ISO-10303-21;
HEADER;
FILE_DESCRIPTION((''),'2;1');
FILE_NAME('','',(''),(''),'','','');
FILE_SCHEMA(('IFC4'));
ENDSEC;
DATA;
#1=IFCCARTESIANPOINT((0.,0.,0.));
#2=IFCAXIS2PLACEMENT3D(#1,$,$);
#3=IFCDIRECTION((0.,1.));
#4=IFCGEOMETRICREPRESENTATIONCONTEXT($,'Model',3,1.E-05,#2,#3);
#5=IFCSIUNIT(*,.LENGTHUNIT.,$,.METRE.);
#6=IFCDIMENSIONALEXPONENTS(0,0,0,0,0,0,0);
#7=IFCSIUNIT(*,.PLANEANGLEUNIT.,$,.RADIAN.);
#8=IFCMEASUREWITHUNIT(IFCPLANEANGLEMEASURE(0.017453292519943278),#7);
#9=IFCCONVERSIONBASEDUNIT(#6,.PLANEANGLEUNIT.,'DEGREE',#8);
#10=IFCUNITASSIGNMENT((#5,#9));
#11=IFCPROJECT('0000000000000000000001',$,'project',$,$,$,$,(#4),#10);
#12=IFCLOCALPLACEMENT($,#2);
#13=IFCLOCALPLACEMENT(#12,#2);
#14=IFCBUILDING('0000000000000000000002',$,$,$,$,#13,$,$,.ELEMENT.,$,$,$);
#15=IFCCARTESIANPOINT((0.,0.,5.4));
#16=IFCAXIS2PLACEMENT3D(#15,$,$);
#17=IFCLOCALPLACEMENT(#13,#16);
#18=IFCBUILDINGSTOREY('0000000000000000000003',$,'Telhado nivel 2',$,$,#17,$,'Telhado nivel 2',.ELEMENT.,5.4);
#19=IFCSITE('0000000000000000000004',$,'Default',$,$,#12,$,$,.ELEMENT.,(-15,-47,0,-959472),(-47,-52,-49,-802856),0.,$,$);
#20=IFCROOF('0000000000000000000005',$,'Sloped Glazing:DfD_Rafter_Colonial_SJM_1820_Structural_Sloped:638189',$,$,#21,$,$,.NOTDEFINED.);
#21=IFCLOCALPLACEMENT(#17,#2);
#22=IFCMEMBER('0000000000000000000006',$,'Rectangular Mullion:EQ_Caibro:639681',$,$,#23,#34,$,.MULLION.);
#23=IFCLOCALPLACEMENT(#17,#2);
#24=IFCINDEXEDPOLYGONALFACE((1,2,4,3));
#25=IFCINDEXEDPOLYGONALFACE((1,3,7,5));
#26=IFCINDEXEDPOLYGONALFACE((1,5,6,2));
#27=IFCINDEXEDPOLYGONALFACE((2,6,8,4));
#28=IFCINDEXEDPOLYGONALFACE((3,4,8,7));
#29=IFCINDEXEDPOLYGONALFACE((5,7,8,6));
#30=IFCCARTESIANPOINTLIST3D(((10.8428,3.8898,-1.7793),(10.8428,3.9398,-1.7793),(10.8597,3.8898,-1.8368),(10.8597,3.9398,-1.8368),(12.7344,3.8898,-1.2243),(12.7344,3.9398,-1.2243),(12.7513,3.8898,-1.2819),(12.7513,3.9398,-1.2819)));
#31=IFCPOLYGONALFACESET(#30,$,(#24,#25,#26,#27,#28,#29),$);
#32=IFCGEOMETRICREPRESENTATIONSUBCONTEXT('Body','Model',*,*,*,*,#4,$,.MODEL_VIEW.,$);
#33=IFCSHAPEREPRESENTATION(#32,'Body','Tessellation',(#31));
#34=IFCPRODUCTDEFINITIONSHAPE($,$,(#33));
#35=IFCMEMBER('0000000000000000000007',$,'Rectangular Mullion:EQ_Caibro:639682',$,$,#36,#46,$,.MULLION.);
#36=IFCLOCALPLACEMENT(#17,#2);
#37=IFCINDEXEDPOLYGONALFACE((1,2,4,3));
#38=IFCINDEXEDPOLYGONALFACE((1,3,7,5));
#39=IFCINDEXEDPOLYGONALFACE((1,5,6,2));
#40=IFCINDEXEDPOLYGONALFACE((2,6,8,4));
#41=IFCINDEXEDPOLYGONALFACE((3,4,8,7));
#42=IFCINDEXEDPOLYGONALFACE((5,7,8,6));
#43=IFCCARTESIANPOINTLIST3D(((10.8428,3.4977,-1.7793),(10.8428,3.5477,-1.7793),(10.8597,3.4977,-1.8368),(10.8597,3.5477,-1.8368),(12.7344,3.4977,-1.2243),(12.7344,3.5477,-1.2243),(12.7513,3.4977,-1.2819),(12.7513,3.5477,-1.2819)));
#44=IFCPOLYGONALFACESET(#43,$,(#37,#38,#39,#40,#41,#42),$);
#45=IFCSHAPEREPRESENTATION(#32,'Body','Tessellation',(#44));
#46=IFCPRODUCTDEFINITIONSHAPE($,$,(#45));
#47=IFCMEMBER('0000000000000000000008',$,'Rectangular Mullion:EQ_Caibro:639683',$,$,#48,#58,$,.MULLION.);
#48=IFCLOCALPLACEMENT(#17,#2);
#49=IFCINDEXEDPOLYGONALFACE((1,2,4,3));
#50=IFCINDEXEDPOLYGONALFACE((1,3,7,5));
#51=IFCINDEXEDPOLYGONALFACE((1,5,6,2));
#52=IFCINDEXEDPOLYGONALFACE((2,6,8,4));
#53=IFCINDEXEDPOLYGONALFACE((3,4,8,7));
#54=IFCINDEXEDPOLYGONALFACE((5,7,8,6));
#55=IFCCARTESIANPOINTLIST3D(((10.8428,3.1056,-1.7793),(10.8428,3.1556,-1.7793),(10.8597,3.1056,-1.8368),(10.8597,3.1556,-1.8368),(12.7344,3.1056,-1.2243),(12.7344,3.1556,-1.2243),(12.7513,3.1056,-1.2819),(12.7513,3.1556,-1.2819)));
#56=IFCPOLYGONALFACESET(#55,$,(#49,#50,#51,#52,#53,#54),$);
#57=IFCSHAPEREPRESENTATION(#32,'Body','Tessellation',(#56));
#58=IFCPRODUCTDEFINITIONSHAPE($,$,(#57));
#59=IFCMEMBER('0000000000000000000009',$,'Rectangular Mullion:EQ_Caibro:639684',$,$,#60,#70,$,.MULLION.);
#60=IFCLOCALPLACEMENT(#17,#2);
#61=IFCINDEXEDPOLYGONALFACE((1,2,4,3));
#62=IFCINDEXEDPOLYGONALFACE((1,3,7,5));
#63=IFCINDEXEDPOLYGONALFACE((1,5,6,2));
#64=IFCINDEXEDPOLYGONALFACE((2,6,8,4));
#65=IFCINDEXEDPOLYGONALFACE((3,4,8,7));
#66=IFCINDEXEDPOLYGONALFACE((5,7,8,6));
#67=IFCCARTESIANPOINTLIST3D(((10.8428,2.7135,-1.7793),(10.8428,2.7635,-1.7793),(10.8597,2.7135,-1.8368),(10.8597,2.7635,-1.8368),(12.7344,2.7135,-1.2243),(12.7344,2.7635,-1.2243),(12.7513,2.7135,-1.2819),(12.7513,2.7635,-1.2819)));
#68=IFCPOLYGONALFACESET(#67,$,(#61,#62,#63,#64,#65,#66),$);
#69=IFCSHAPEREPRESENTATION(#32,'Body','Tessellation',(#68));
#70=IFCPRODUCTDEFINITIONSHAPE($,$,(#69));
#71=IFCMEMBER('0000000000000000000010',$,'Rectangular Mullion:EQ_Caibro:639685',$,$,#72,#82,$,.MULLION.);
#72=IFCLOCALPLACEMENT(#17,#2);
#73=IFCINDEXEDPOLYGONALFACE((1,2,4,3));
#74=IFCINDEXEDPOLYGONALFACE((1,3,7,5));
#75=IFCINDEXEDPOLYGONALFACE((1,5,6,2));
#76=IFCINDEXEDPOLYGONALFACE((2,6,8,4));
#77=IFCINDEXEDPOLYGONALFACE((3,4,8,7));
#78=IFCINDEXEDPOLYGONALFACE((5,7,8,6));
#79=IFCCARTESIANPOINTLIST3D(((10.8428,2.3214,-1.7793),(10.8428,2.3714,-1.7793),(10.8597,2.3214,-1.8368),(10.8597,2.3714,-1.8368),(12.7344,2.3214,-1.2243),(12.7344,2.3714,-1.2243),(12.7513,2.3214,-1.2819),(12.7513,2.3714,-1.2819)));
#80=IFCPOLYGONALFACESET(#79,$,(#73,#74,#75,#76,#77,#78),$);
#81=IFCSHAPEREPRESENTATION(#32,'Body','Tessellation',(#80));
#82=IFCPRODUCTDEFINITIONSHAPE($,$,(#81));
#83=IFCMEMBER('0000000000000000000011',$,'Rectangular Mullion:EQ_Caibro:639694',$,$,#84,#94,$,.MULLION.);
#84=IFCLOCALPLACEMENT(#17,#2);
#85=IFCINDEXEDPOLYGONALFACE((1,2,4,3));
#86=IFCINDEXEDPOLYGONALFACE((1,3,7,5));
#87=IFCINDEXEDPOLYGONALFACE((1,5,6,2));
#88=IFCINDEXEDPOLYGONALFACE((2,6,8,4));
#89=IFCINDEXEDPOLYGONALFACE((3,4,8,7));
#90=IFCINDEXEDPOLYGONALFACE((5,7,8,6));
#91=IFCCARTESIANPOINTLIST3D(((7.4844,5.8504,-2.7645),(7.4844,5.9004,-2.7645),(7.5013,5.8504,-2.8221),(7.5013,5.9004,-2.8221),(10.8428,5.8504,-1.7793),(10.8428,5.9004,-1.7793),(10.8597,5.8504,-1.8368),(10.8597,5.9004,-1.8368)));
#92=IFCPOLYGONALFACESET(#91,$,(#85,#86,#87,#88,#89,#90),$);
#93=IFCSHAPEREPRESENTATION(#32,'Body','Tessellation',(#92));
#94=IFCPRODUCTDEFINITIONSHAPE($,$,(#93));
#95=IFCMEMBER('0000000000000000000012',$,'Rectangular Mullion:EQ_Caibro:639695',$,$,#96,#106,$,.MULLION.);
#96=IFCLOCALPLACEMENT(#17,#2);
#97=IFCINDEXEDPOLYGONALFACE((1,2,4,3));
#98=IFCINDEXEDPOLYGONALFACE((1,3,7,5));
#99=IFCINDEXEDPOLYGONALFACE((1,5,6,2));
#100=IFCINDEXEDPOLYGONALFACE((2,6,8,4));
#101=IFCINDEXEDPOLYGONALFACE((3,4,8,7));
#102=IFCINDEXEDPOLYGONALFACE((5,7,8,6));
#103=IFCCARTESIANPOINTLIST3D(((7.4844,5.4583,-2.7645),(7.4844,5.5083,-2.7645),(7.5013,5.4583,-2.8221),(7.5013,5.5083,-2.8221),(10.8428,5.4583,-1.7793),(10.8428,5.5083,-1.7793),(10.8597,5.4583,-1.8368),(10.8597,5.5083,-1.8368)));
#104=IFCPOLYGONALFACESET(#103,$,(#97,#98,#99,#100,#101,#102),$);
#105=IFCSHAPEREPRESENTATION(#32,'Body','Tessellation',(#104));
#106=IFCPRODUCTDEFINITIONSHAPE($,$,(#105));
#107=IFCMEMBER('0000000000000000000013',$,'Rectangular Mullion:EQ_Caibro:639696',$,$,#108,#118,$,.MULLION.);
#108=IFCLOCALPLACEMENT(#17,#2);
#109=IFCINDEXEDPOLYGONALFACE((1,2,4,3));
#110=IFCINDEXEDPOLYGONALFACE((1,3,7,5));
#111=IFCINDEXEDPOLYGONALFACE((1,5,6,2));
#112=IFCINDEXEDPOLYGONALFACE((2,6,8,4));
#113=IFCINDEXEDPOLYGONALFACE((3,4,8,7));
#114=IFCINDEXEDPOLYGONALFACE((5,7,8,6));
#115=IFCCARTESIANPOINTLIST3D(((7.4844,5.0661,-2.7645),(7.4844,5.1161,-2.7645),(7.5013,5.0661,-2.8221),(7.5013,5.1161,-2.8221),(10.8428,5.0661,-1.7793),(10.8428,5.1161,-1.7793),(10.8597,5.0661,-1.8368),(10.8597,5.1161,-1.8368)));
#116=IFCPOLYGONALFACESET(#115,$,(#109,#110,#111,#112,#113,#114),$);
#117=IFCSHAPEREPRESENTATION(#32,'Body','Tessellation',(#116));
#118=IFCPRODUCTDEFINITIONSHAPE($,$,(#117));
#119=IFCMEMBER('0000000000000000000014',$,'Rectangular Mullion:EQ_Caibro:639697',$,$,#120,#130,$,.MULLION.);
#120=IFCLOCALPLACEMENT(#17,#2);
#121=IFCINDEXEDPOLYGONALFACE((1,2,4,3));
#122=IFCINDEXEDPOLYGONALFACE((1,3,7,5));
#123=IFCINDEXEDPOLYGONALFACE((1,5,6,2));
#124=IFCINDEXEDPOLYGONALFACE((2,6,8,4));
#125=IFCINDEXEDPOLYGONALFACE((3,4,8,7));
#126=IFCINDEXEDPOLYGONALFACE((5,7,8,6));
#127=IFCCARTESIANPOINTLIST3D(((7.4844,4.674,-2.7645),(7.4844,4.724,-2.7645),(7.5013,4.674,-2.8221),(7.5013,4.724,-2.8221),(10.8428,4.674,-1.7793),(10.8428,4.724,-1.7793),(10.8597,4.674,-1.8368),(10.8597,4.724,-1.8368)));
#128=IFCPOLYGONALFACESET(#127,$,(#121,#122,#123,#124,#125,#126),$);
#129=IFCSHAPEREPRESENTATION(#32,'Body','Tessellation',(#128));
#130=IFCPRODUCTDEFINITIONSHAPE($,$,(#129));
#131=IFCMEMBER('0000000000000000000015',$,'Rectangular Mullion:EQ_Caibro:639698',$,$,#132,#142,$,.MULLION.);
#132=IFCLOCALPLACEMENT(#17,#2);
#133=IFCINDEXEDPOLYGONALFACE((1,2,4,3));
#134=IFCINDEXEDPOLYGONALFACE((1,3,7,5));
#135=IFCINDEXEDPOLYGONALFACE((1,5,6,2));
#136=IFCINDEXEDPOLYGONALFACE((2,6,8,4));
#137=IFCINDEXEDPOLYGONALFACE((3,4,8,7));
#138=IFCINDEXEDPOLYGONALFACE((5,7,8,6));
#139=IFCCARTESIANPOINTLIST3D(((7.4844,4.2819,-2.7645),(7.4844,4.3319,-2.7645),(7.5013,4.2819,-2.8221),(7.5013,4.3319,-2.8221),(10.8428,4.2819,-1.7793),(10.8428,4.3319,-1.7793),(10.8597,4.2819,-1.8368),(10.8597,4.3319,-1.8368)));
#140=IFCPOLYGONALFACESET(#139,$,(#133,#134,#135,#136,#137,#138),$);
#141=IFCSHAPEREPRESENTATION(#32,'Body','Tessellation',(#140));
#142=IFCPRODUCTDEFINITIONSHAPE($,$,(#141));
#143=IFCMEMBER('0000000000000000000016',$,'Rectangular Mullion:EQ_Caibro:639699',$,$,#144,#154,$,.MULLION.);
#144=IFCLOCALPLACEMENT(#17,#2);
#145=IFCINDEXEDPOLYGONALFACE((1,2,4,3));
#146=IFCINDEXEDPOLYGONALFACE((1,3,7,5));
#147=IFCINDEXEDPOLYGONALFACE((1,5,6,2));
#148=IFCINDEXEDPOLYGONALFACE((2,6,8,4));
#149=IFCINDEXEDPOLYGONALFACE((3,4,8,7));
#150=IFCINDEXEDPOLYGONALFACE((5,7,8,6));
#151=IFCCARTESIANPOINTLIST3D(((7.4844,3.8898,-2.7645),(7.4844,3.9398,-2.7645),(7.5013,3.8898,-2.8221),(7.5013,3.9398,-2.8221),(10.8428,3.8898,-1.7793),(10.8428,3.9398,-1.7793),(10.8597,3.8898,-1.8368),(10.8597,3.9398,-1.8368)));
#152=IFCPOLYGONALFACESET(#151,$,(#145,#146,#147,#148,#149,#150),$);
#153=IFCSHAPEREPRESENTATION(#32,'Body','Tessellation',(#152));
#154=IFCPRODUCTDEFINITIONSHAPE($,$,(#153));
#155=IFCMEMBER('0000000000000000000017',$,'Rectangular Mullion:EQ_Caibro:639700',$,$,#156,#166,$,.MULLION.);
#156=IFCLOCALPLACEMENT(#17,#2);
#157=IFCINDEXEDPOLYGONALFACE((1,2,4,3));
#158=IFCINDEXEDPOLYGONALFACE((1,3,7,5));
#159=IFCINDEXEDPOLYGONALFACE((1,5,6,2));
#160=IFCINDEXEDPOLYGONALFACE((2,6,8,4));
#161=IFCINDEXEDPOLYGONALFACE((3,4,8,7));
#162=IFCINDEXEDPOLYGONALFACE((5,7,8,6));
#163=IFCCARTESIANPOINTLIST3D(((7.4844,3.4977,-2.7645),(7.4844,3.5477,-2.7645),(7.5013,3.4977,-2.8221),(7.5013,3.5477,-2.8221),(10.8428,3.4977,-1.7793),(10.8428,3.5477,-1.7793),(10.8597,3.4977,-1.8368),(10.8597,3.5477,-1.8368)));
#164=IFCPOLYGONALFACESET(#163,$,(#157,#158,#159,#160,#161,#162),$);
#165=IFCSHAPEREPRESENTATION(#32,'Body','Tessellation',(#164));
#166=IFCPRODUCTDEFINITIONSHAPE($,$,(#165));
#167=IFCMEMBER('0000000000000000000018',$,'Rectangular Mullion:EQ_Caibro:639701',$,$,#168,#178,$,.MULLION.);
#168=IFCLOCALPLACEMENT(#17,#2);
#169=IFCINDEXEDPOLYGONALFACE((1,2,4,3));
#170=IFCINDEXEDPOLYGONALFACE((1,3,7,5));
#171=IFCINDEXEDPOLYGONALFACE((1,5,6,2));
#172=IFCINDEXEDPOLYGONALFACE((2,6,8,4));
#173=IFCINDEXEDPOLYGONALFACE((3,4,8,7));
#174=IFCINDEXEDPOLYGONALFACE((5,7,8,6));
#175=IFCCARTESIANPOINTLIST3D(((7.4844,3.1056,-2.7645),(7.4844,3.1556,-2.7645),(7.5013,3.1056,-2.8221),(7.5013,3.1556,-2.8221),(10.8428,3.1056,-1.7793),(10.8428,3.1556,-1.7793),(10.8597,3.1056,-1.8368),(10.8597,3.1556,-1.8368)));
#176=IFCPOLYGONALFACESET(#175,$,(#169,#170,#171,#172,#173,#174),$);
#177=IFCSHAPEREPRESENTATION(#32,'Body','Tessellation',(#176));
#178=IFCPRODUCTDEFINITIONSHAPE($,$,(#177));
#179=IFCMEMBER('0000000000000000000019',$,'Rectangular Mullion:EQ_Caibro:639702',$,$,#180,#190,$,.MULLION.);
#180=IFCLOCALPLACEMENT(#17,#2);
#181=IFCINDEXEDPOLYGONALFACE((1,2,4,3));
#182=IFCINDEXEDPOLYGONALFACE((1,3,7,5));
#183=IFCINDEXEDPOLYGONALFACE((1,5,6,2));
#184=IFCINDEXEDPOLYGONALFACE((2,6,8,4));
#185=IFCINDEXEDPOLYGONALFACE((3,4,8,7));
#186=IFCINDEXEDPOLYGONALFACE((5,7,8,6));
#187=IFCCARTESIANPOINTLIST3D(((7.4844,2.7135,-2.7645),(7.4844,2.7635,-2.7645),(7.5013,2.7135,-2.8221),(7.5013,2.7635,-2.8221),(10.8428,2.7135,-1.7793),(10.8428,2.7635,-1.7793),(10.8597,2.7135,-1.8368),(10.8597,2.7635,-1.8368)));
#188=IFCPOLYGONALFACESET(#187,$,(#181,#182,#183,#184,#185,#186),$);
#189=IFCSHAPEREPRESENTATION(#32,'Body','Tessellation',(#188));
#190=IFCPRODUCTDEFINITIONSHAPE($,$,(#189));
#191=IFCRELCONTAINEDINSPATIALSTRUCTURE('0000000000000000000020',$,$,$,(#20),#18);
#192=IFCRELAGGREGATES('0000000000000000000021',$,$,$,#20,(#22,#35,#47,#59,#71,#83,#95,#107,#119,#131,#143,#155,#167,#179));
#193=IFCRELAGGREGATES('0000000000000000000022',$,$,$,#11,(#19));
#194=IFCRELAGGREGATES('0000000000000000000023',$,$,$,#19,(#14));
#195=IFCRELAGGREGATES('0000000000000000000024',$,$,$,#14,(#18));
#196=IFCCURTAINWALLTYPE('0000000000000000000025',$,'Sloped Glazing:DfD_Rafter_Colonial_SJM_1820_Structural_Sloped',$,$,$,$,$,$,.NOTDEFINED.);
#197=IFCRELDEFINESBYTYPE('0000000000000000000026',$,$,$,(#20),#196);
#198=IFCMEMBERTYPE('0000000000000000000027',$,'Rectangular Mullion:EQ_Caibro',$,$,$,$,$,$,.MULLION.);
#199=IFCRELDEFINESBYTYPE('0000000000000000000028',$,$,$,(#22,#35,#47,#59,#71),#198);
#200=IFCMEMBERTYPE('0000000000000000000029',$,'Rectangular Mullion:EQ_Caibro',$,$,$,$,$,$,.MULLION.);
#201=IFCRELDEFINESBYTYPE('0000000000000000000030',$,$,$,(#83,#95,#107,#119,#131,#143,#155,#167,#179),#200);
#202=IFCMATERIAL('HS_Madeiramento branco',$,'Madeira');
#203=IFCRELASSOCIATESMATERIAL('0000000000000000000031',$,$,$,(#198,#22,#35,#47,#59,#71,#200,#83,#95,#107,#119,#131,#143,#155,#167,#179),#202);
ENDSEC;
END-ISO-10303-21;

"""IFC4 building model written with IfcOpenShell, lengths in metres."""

from ifc_helpers import new_model, entity, si_unit, converted_unit, direction, frame, origin, place, context, subcontext, project, spatial, indexed_curve, outline, extrude, source, transform, mapped, material, type_object, type_shapes, element, aggregate, save


model = new_model("IFC4")

# Units and contexts
model_context = context("Model", 3, precision=1e-05, world=origin(), true_north=direction((0.0, 1.0)))
body_context = subcontext(model_context, "Body", "Model", "MODEL_VIEW")
ifc_project = project(units=[si_unit("LENGTHUNIT", "METRE"), converted_unit("PLANEANGLEUNIT", "DEGREE", entity("IfcPlaneAngleMeasure", 0.017453292519943278), si_unit("PLANEANGLEUNIT", "RADIAN"), dimensions=[0, 0, 0, 0, 0, 0, 0])], contexts=[model_context])

# Site, building, storey
site_placement = place(None, origin())
site = spatial("IfcSite", under=ifc_project, at=site_placement, Name="Default", CompositionType="ELEMENT", RefLatitude=(-15, -47, 0, -959472), RefLongitude=(-47, -52, -49, -802856), RefElevation=0.0)
building_placement = place(site_placement, origin())
building = spatial("IfcBuilding", under=site, at=building_placement, CompositionType="ELEMENT")
storey_placement = place(building_placement, frame((0.0, 0.0, 5.4)))
storey = spatial("IfcBuildingStorey", under=building, at=storey_placement, Name="Telhado nivel 2", LongName="Telhado nivel 2", CompositionType="ELEMENT", Elevation=5.4)

# Roof, members
curtain_wall_type = type_object("IfcCurtainWallType", Name="Sloped Glazing:DfD_Rafter_Colonial_SJM_1820_Structural_Sloped", PredefinedType="NOTDEFINED")
ifc_material = material(Name="HS_Madeiramento branco", Category="Madeira")
roof_1_placement = place(storey_placement, frame((0.0, 0.0, -5.4)))
roof_1 = element("IfcRoof", 1, at=roof_1_placement, inside=storey, type_object=curtain_wall_type, Name="Sloped Glazing:DfD_Rafter_Colonial_SJM_1820_Structural_Sloped:638189", PredefinedType="NOTDEFINED")
member_type_1 = type_object("IfcMemberType", Name="Rectangular Mullion:EQ_Caibro", PredefinedType="MULLION", material=ifc_material)
shared_shape_1 = source(origin(), body_context, "Body", "SweptSolid", [
    extrude(outline(indexed_curve([(-0.025, -0.03), (0.025, -0.03), (0.025, 0.03), (-0.025, 0.03), (-0.025, -0.03)], self_intersect=False)), frame((0.0, -0.03, -1.9713), z_axis=(0.0, 0.0, 1.0), x_axis=(-1.0, 0.0, 0.0)), (0.0, 0.0, 1.0), 1.9713),
])
type_shapes(member_type_1, [shared_shape_1])
member_1_placement = place(roof_1_placement, frame((12.7513, 3.9148, 4.1181), z_axis=(0.95956, 0.0, 0.281504), x_axis=(0.0, -1.0, 0.0)))
member_1 = element("IfcMember", 2, at=member_1_placement, type_object=member_type_1, material=ifc_material, Name="Rectangular Mullion:EQ_Caibro:639681", PredefinedType="MULLION", context=body_context, shape_type="MappedRepresentation", body=[
    mapped(shared_shape_1, transform((0.0, 0.0, 0.0), scale=1.0)),
])
member_2_placement = place(roof_1_placement, frame((12.7513, 3.5227, 4.1181), z_axis=(0.95956, 0.0, 0.281504), x_axis=(0.0, -1.0, 0.0)))
member_2 = element("IfcMember", 3, at=member_2_placement, type_object=member_type_1, material=ifc_material, Name="Rectangular Mullion:EQ_Caibro:639682", PredefinedType="MULLION", context=body_context, shape_type="MappedRepresentation", body=[
    mapped(shared_shape_1, transform((0.0, 0.0, 0.0), scale=1.0)),
])
member_3_placement = place(roof_1_placement, frame((12.7513, 3.1306, 4.1181), z_axis=(0.95956, 0.0, 0.281504), x_axis=(0.0, -1.0, 0.0)))
member_3 = element("IfcMember", 4, at=member_3_placement, type_object=member_type_1, material=ifc_material, Name="Rectangular Mullion:EQ_Caibro:639683", PredefinedType="MULLION", context=body_context, shape_type="MappedRepresentation", body=[
    mapped(shared_shape_1, transform((0.0, 0.0, 0.0), scale=1.0)),
])
member_4_placement = place(roof_1_placement, frame((12.7513, 2.7385, 4.1181), z_axis=(0.95956, 0.0, 0.281504), x_axis=(0.0, -1.0, 0.0)))
member_4 = element("IfcMember", 5, at=member_4_placement, type_object=member_type_1, material=ifc_material, Name="Rectangular Mullion:EQ_Caibro:639684", PredefinedType="MULLION", context=body_context, shape_type="MappedRepresentation", body=[
    mapped(shared_shape_1, transform((0.0, 0.0, 0.0), scale=1.0)),
])
member_5_placement = place(roof_1_placement, frame((12.7513, 2.3464, 4.1181), z_axis=(0.95956, 0.0, 0.281504), x_axis=(0.0, -1.0, 0.0)))
member_5 = element("IfcMember", 6, at=member_5_placement, type_object=member_type_1, material=ifc_material, Name="Rectangular Mullion:EQ_Caibro:639685", PredefinedType="MULLION", context=body_context, shape_type="MappedRepresentation", body=[
    mapped(shared_shape_1, transform((0.0, 0.0, 0.0), scale=1.0)),
])
member_type_2 = type_object("IfcMemberType", Name="Rectangular Mullion:EQ_Caibro", PredefinedType="MULLION", material=ifc_material)
shared_shape_2 = source(origin(), body_context, "Body", "SweptSolid", [
    extrude(outline(indexed_curve([(-0.025, -0.03), (0.025, -0.03), (0.025, 0.03), (-0.025, 0.03), (-0.025, -0.03)], self_intersect=False)), frame((0.0, -0.03, -3.5), z_axis=(0.0, 0.0, 1.0), x_axis=(-1.0, 0.0, 0.0)), (0.0, 0.0, 1.0), 3.5),
])
type_shapes(member_type_2, [shared_shape_2])
member_6_placement = place(roof_1_placement, frame((10.8597, 5.8754, 3.5632), z_axis=(0.95956, 0.0, 0.281504), x_axis=(0.0, -1.0, 0.0)))
member_6 = element("IfcMember", 7, at=member_6_placement, type_object=member_type_2, material=ifc_material, Name="Rectangular Mullion:EQ_Caibro:639694", PredefinedType="MULLION", context=body_context, shape_type="MappedRepresentation", body=[
    mapped(shared_shape_2, transform((0.0, 0.0, 0.0), scale=1.0)),
])
member_7_placement = place(roof_1_placement, frame((10.8597, 5.4833, 3.5632), z_axis=(0.95956, 0.0, 0.281504), x_axis=(0.0, -1.0, 0.0)))
member_7 = element("IfcMember", 8, at=member_7_placement, type_object=member_type_2, material=ifc_material, Name="Rectangular Mullion:EQ_Caibro:639695", PredefinedType="MULLION", context=body_context, shape_type="MappedRepresentation", body=[
    mapped(shared_shape_2, transform((0.0, 0.0, 0.0), scale=1.0)),
])
member_8_placement = place(roof_1_placement, frame((10.8597, 5.0911, 3.5632), z_axis=(0.95956, 0.0, 0.281504), x_axis=(0.0, -1.0, 0.0)))
member_8 = element("IfcMember", 9, at=member_8_placement, type_object=member_type_2, material=ifc_material, Name="Rectangular Mullion:EQ_Caibro:639696", PredefinedType="MULLION", context=body_context, shape_type="MappedRepresentation", body=[
    mapped(shared_shape_2, transform((0.0, 0.0, 0.0), scale=1.0)),
])
member_9_placement = place(roof_1_placement, frame((10.8597, 4.699, 3.5632), z_axis=(0.95956, 0.0, 0.281504), x_axis=(0.0, -1.0, 0.0)))
member_9 = element("IfcMember", 10, at=member_9_placement, type_object=member_type_2, material=ifc_material, Name="Rectangular Mullion:EQ_Caibro:639697", PredefinedType="MULLION", context=body_context, shape_type="MappedRepresentation", body=[
    mapped(shared_shape_2, transform((0.0, 0.0, 0.0), scale=1.0)),
])
member_10_placement = place(roof_1_placement, frame((10.8597, 4.3069, 3.5632), z_axis=(0.95956, 0.0, 0.281504), x_axis=(0.0, -1.0, 0.0)))
member_10 = element("IfcMember", 11, at=member_10_placement, type_object=member_type_2, material=ifc_material, Name="Rectangular Mullion:EQ_Caibro:639698", PredefinedType="MULLION", context=body_context, shape_type="MappedRepresentation", body=[
    mapped(shared_shape_2, transform((0.0, 0.0, 0.0), scale=1.0)),
])
member_11_placement = place(roof_1_placement, frame((10.8597, 3.9148, 3.5632), z_axis=(0.95956, 0.0, 0.281504), x_axis=(0.0, -1.0, 0.0)))
member_11 = element("IfcMember", 12, at=member_11_placement, type_object=member_type_2, material=ifc_material, Name="Rectangular Mullion:EQ_Caibro:639699", PredefinedType="MULLION", context=body_context, shape_type="MappedRepresentation", body=[
    mapped(shared_shape_2, transform((0.0, 0.0, 0.0), scale=1.0)),
])
member_12_placement = place(roof_1_placement, frame((10.8597, 3.5227, 3.5632), z_axis=(0.95956, 0.0, 0.281504), x_axis=(0.0, -1.0, 0.0)))
member_12 = element("IfcMember", 13, at=member_12_placement, type_object=member_type_2, material=ifc_material, Name="Rectangular Mullion:EQ_Caibro:639700", PredefinedType="MULLION", context=body_context, shape_type="MappedRepresentation", body=[
    mapped(shared_shape_2, transform((0.0, 0.0, 0.0), scale=1.0)),
])
member_13_placement = place(roof_1_placement, frame((10.8597, 3.1306, 3.5632), z_axis=(0.95956, 0.0, 0.281504), x_axis=(0.0, -1.0, 0.0)))
member_13 = element("IfcMember", 14, at=member_13_placement, type_object=member_type_2, material=ifc_material, Name="Rectangular Mullion:EQ_Caibro:639701", PredefinedType="MULLION", context=body_context, shape_type="MappedRepresentation", body=[
    mapped(shared_shape_2, transform((0.0, 0.0, 0.0), scale=1.0)),
])
member_14_placement = place(roof_1_placement, frame((10.8597, 2.7385, 3.5632), z_axis=(0.95956, 0.0, 0.281504), x_axis=(0.0, -1.0, 0.0)))
member_14 = element("IfcMember", 15, at=member_14_placement, type_object=member_type_2, material=ifc_material, Name="Rectangular Mullion:EQ_Caibro:639702", PredefinedType="MULLION", context=body_context, shape_type="MappedRepresentation", body=[
    mapped(shared_shape_2, transform((0.0, 0.0, 0.0), scale=1.0)),
])
aggregate(roof_1, [member_1, member_2, member_3, member_4, member_5, member_6, member_7, member_8, member_9, member_10, member_11, member_12, member_13, member_14])

save(model, "model.ifc")
